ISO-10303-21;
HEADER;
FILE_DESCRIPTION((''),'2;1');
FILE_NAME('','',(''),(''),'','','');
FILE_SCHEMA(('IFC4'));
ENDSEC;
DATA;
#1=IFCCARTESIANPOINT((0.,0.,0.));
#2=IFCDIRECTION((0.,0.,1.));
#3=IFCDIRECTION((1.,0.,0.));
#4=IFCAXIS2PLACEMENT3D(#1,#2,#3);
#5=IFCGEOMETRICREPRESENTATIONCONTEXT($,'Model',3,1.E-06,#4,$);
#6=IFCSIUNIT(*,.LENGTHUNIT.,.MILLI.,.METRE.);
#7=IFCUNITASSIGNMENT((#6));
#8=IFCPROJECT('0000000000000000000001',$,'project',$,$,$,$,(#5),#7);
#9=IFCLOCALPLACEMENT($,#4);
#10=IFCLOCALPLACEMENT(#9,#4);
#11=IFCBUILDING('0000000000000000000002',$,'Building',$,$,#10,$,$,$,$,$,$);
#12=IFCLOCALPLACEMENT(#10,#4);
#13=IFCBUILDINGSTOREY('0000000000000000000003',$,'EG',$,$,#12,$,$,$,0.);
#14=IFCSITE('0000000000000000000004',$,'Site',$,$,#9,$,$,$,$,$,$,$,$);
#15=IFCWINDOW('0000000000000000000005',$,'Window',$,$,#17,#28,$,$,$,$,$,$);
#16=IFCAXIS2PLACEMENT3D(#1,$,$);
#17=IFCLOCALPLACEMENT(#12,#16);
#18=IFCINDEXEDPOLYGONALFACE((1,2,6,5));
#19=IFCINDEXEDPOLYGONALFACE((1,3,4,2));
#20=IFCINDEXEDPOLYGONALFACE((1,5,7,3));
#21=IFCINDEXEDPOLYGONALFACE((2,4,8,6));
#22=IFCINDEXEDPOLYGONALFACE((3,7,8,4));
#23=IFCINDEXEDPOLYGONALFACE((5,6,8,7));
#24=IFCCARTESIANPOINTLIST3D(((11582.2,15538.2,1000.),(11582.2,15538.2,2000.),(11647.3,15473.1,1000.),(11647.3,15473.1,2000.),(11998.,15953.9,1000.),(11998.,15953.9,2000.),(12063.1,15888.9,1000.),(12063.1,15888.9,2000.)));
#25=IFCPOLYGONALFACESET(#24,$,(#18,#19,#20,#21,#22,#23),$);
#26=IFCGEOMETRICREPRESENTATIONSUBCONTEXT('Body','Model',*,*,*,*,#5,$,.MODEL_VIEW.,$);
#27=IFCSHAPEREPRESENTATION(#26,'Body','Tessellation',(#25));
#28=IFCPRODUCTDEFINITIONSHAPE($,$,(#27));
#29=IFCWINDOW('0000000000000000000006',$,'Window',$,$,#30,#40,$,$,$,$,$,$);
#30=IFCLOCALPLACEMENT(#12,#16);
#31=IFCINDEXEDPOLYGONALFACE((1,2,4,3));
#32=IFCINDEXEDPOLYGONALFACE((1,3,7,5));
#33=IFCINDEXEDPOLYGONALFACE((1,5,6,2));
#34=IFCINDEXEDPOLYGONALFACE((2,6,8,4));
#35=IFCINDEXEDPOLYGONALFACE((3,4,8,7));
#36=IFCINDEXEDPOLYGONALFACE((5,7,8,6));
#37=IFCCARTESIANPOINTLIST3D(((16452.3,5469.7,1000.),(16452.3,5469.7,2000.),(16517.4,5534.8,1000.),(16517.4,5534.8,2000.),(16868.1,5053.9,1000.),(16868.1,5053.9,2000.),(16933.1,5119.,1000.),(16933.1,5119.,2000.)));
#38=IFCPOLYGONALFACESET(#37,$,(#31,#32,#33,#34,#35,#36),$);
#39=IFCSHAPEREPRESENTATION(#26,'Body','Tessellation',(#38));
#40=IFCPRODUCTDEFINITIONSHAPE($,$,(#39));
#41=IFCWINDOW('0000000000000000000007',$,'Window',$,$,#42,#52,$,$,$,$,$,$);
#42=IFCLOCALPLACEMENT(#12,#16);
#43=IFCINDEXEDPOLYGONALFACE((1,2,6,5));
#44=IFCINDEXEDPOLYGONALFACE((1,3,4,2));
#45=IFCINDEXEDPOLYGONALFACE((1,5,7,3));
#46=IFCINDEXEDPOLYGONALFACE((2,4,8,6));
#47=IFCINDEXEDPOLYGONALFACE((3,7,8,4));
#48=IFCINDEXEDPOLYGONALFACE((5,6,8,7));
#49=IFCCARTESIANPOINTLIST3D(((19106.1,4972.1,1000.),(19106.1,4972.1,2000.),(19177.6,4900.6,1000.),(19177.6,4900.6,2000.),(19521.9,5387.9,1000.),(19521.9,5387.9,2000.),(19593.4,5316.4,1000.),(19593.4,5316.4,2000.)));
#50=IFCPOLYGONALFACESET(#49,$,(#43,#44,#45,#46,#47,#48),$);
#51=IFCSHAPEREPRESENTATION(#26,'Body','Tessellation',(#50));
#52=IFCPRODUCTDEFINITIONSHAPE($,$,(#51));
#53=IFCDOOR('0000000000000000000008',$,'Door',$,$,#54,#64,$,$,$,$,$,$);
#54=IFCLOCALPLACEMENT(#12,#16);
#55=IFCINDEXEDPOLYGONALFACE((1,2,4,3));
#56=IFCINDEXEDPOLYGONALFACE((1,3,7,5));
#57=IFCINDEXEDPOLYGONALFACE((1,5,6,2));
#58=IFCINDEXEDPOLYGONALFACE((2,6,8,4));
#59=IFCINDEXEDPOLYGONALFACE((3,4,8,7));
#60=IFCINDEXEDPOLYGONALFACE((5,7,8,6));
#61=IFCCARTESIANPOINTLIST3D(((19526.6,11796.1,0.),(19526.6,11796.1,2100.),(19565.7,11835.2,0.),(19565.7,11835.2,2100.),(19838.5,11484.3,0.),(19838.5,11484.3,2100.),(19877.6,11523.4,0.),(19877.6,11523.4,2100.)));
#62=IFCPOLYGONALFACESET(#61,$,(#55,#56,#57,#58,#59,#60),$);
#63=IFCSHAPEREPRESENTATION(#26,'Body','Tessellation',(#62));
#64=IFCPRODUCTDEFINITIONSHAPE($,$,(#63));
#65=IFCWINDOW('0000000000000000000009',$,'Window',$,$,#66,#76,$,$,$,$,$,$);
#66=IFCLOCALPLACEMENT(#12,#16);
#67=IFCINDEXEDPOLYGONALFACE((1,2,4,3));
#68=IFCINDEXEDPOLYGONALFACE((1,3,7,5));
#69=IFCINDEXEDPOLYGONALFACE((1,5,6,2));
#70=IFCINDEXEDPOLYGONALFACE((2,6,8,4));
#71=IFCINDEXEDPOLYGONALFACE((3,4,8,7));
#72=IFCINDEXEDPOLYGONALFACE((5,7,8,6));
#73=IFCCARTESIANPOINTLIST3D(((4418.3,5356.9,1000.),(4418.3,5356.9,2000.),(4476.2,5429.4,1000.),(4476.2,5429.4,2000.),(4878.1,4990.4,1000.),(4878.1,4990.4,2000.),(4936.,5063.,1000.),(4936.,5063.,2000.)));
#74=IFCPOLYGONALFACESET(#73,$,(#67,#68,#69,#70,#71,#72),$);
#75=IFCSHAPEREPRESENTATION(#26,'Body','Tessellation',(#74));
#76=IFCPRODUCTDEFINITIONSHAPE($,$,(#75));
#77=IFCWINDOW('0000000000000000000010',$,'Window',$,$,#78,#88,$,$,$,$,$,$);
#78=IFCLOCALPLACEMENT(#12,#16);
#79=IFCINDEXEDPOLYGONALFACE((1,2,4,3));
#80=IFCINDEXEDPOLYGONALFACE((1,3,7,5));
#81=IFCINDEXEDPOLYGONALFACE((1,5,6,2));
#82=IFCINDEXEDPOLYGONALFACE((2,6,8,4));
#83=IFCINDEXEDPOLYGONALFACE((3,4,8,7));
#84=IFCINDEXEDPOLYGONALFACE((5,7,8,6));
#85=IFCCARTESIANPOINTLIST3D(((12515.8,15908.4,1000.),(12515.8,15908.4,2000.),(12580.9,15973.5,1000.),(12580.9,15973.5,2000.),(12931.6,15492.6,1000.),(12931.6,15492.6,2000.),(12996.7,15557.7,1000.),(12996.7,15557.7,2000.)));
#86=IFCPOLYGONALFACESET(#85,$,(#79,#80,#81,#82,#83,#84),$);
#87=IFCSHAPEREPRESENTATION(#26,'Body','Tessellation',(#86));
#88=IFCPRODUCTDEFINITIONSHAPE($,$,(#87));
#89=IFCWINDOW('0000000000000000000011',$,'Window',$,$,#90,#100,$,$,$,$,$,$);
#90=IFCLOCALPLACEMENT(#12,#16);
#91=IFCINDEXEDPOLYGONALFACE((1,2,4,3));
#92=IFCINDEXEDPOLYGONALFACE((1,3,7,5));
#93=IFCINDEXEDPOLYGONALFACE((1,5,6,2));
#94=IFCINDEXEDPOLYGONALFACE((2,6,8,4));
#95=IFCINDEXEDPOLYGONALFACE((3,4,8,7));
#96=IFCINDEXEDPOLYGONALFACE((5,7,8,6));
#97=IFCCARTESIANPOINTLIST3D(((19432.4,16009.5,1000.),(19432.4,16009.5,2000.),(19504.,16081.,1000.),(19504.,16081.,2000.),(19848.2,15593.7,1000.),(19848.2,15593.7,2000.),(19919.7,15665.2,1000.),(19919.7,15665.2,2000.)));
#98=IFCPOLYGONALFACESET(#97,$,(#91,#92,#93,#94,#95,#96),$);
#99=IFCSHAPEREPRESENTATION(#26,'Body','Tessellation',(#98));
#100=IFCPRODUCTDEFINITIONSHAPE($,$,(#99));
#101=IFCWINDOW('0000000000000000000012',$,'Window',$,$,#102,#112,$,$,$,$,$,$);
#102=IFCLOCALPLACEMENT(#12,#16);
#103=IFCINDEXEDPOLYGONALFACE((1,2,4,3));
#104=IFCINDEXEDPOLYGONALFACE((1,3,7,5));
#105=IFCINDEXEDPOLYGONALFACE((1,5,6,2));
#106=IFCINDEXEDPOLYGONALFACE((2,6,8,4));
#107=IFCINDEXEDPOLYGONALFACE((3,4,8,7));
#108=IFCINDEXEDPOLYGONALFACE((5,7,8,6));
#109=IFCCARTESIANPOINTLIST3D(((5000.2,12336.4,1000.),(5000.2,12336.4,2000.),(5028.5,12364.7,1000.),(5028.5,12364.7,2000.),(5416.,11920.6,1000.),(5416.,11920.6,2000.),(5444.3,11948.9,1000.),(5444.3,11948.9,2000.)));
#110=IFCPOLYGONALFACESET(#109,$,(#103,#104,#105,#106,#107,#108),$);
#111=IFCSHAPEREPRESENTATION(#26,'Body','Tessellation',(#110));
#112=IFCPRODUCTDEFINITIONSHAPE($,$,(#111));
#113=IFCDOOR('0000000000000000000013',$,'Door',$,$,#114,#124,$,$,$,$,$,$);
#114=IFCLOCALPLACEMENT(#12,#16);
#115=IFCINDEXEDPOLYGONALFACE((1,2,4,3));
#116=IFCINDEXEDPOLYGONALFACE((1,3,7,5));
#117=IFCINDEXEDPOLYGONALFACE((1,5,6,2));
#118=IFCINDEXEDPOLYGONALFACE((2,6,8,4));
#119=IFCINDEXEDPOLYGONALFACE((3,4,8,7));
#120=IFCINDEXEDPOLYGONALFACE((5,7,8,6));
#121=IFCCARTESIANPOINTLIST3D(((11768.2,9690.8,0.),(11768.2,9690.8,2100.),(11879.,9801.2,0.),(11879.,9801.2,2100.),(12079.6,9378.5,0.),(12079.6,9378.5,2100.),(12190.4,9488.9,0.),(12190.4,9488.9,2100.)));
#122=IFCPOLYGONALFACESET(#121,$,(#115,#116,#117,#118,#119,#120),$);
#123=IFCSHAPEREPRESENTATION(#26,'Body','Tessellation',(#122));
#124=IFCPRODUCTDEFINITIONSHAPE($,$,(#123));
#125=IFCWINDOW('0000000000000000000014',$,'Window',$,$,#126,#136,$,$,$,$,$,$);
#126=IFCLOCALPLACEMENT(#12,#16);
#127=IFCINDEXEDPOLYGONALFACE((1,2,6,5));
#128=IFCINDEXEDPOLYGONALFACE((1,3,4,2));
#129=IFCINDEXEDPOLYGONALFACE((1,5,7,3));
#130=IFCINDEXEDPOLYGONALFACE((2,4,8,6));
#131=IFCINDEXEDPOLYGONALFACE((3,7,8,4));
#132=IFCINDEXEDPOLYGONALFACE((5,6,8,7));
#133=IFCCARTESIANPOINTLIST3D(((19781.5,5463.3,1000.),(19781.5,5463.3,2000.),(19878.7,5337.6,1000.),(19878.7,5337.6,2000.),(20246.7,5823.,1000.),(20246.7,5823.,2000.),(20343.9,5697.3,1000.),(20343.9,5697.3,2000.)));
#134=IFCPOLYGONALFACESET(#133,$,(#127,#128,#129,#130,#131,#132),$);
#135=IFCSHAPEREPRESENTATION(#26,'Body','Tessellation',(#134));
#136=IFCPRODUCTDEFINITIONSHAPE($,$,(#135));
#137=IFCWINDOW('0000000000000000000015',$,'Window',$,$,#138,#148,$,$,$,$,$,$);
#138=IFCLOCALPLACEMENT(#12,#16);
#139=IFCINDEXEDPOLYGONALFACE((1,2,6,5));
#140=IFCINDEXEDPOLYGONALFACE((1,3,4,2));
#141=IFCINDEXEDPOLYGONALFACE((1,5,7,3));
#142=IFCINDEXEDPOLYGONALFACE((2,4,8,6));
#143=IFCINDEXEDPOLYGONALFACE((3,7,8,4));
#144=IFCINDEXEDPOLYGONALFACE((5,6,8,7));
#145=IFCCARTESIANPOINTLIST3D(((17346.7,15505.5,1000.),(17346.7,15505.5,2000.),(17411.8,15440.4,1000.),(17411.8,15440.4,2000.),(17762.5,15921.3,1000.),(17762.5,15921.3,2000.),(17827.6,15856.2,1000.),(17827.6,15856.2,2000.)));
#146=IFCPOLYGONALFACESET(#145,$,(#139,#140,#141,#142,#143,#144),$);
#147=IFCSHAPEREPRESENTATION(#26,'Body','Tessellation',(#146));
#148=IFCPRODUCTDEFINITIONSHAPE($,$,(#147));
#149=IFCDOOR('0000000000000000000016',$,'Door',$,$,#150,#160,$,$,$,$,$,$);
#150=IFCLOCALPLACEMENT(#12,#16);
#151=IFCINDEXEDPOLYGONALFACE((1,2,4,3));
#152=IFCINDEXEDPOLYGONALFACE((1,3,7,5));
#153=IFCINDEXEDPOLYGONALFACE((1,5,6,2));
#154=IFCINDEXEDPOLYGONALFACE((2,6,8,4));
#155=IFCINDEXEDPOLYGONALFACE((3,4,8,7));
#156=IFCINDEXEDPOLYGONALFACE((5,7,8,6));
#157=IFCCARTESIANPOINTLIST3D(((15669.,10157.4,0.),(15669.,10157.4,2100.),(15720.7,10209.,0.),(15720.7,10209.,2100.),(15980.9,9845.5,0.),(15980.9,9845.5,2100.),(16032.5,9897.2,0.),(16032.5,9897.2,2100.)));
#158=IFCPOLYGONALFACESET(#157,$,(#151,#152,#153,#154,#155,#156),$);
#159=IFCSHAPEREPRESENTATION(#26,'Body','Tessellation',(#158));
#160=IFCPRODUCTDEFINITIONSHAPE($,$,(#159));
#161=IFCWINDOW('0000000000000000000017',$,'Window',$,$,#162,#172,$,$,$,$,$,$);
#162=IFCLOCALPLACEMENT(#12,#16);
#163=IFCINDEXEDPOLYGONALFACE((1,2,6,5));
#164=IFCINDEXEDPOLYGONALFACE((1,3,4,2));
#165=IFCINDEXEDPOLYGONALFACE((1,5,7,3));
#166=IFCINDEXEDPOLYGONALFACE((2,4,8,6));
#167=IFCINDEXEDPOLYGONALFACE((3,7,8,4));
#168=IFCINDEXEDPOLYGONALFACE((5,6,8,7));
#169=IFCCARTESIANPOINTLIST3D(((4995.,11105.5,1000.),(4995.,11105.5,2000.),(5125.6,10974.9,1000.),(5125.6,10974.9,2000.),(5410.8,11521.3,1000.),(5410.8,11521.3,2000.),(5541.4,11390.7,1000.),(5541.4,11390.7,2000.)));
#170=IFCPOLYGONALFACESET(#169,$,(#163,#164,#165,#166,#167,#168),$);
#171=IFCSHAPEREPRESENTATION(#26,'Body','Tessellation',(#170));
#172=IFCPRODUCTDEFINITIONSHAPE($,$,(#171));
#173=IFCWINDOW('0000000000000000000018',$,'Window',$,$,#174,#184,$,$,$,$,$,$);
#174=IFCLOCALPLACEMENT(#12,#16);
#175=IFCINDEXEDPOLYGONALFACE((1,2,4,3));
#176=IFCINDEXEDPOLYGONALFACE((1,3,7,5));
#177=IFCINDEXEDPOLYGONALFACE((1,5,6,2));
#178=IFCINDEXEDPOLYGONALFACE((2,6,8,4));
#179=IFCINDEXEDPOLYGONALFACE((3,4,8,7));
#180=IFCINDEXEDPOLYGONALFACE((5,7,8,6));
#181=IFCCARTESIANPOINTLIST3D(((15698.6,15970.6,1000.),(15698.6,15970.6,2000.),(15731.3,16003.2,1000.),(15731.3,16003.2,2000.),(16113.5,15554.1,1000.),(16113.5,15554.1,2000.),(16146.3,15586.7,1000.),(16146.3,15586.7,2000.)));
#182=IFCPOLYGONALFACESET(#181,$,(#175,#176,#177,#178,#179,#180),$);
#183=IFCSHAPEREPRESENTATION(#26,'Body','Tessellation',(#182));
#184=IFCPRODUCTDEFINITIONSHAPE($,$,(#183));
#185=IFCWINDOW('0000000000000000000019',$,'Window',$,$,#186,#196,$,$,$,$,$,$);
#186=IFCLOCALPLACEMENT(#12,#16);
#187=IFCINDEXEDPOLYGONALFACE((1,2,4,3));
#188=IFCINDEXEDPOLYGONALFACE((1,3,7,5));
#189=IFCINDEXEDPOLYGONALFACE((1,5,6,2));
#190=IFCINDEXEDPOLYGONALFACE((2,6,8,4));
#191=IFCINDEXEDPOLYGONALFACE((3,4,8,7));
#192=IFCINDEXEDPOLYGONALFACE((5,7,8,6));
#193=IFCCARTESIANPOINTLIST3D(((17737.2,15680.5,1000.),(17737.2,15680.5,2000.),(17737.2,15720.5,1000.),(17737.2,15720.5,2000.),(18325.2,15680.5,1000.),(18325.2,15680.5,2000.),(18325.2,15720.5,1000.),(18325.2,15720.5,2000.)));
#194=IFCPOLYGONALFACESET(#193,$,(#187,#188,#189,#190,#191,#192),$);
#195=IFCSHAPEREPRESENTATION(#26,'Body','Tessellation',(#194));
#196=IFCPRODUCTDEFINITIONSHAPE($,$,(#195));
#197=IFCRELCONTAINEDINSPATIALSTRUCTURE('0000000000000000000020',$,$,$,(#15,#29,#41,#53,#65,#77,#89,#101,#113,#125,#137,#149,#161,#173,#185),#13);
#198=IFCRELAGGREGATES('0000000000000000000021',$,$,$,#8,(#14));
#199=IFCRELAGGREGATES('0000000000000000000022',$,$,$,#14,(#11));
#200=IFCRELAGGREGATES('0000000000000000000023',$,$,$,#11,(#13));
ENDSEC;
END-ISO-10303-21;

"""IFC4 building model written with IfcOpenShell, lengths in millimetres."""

from ifc_helpers import new_model, si_unit, frame, origin_with_axes, place, context, subcontext, project, spatial, rectangle, extrude, element, save


model = new_model("IFC4")

# Units and contexts
model_context = context("Model", 3, precision=1e-06, world=origin_with_axes())
body_context = subcontext(model_context, "Body", "Model", "MODEL_VIEW")
ifc_project = project(units=[si_unit("LENGTHUNIT", "METRE", prefix="MILLI")], contexts=[model_context])

# Site, building, storey
site_placement = place(None, origin_with_axes())
site = spatial("IfcSite", under=ifc_project, at=site_placement, Name="Site")
building_placement = place(site_placement, origin_with_axes())
building = spatial("IfcBuilding", under=site, at=building_placement, Name="Building")
storey_placement = place(building_placement, origin_with_axes())
storey = spatial("IfcBuildingStorey", under=building, at=storey_placement, Name="EG", Elevation=0.0)

# Windows
window_1_placement = place(storey_placement, origin_with_axes())
element("IfcWindow", 1, at=window_1_placement, inside=storey, Name="Window", context=body_context, shape_type="SweptSolid", body=[
    extrude(rectangle(XDim=588.0, YDim=92.0), frame((11822.7, 15713.5, 1000.0), z_axis=(0.0, 0.0, 1.0), x_axis=(-0.707107, -0.707107, 0.0)), (0.0, 0.0, 1.0), 1000.0),
])
window_2_placement = place(storey_placement, origin_with_axes())
element("IfcWindow", 2, at=window_2_placement, inside=storey, Name="Window", context=body_context, shape_type="SweptSolid", body=[
    extrude(rectangle(XDim=588.0, YDim=92.0), frame((16692.7, 5294.3, 1000.0), z_axis=(0.0, 0.0, 1.0), x_axis=(0.707107, -0.707107, 0.0)), (0.0, 0.0, 1.0), 1000.0),
])
window_3_placement = place(storey_placement, origin_with_axes())
element("IfcWindow", 3, at=window_3_placement, inside=storey, Name="Window", context=body_context, shape_type="SweptSolid", body=[
    extrude(rectangle(XDim=588.0, YDim=101.2), frame((19349.7, 5144.3, 1000.0), z_axis=(0.0, 0.0, 1.0), x_axis=(-0.707107, -0.707107, 0.0)), (0.0, 0.0, 1.0), 1000.0),
])

# Door
door_1_placement = place(storey_placement, origin_with_axes())
element("IfcDoor", 4, at=door_1_placement, inside=storey, Name="Door", context=body_context, shape_type="SweptSolid", body=[
    extrude(rectangle(XDim=441.0, YDim=55.3), frame((19702.1, 11659.7, 0.0), z_axis=(0.0, 0.0, 1.0), x_axis=(-0.707107, 0.707107, 0.0)), (0.0, 0.0, 1.0), 2100.0),
])

# Windows
window_4_placement = place(storey_placement, origin_with_axes())
element("IfcWindow", 5, at=window_4_placement, inside=storey, Name="Window", context=body_context, shape_type="SweptSolid", body=[
    extrude(rectangle(XDim=588.0, YDim=92.8), frame((4677.1, 5209.9, 1000.0), z_axis=(0.0, 0.0, 1.0), x_axis=(0.782037, -0.623232, 0.0)), (0.0, 0.0, 1.0), 1000.0),
])
window_5_placement = place(storey_placement, origin_with_axes())
element("IfcWindow", 6, at=window_5_placement, inside=storey, Name="Window", context=body_context, shape_type="SweptSolid", body=[
    extrude(rectangle(XDim=588.0, YDim=92.0), frame((12756.2, 15733.1, 1000.0), z_axis=(0.0, 0.0, 1.0), x_axis=(0.707107, -0.707107, 0.0)), (0.0, 0.0, 1.0), 1000.0),
])
window_6_placement = place(storey_placement, origin_with_axes())
element("IfcWindow", 7, at=window_6_placement, inside=storey, Name="Window", context=body_context, shape_type="SweptSolid", body=[
    extrude(rectangle(XDim=588.0, YDim=101.2), frame((19676.1, 15837.4, 1000.0), z_axis=(0.0, 0.0, 1.0), x_axis=(-0.707107, 0.707107, 0.0)), (0.0, 0.0, 1.0), 1000.0),
])
window_7_placement = place(storey_placement, origin_with_axes())
element("IfcWindow", 8, at=window_7_placement, inside=storey, Name="Window", context=body_context, shape_type="SweptSolid", body=[
    extrude(rectangle(XDim=588.0, YDim=40.0), frame((5222.2, 12142.7, 1000.0), z_axis=(0.0, 0.0, 1.0), x_axis=(0.707107, -0.707107, 0.0)), (0.0, 0.0, 1.0), 1000.0),
])

# Door
door_2_placement = place(storey_placement, origin_with_axes())
element("IfcDoor", 9, at=door_2_placement, inside=storey, Name="Door", context=body_context, shape_type="SweptSolid", body=[
    extrude(rectangle(XDim=441.0, YDim=156.4), frame((11979.3, 9589.9, 0.0), z_axis=(0.0, 0.0, 1.0), x_axis=(0.705982, -0.70823, 0.0)), (0.0, 0.0, 1.0), 2100.0),
])

# Windows
window_8_placement = place(storey_placement, origin_with_axes())
element("IfcWindow", 10, at=window_8_placement, inside=storey, Name="Window", context=body_context, shape_type="SweptSolid", body=[
    extrude(rectangle(XDim=588.0, YDim=158.9), frame((20062.7, 5580.3, 1000.0), z_axis=(0.0, 0.0, 1.0), x_axis=(-0.791133, -0.611644, 0.0)), (0.0, 0.0, 1.0), 1000.0),
])
window_9_placement = place(storey_placement, origin_with_axes())
element("IfcWindow", 11, at=window_9_placement, inside=storey, Name="Window", context=body_context, shape_type="SweptSolid", body=[
    extrude(rectangle(XDim=588.0, YDim=92.0), frame((17587.1, 15680.9, 1000.0), z_axis=(0.0, 0.0, 1.0), x_axis=(-0.707107, -0.707107, 0.0)), (0.0, 0.0, 1.0), 1000.0),
])

# Door
door_3_placement = place(storey_placement, origin_with_axes())
element("IfcDoor", 12, at=door_3_placement, inside=storey, Name="Door", context=body_context, shape_type="SweptSolid", body=[
    extrude(rectangle(XDim=441.0, YDim=73.0), frame((15850.8, 10027.3, 0.0), z_axis=(0.0, 0.0, 1.0), x_axis=(-0.707107, 0.707107, 0.0)), (0.0, 0.0, 1.0), 2100.0),
])

# Windows
window_10_placement = place(storey_placement, origin_with_axes())
element("IfcWindow", 13, at=window_10_placement, inside=storey, Name="Window", context=body_context, shape_type="SweptSolid", body=[
    extrude(rectangle(XDim=588.0, YDim=184.7), frame((5268.2, 11248.1, 1000.0), z_axis=(0.0, 0.0, 1.0), x_axis=(-0.707107, -0.707107, 0.0)), (0.0, 0.0, 1.0), 1000.0),
])
window_11_placement = place(storey_placement, origin_with_axes())
element("IfcWindow", 14, at=window_11_placement, inside=storey, Name="Window", context=body_context, shape_type="SweptSolid", body=[
    extrude(rectangle(XDim=588.0, YDim=46.2), frame((15922.4, 15778.6, 1000.0), z_axis=(0.0, 0.0, 1.0), x_axis=(-0.705748, 0.708463, 0.0)), (0.0, 0.0, 1.0), 1000.0),
])
window_12_placement = place(storey_placement, origin_with_axes())
element("IfcWindow", 15, at=window_12_placement, inside=storey, Name="Window", context=body_context, shape_type="SweptSolid", body=[
    extrude(rectangle(XDim=588.0, YDim=40.0), frame((18031.2, 15700.5, 1000.0), z_axis=(0.0, 0.0, 1.0), x_axis=(1.0, 0.0, 0.0)), (0.0, 0.0, 1.0), 1000.0),
])

save(model, "model.ifc")
